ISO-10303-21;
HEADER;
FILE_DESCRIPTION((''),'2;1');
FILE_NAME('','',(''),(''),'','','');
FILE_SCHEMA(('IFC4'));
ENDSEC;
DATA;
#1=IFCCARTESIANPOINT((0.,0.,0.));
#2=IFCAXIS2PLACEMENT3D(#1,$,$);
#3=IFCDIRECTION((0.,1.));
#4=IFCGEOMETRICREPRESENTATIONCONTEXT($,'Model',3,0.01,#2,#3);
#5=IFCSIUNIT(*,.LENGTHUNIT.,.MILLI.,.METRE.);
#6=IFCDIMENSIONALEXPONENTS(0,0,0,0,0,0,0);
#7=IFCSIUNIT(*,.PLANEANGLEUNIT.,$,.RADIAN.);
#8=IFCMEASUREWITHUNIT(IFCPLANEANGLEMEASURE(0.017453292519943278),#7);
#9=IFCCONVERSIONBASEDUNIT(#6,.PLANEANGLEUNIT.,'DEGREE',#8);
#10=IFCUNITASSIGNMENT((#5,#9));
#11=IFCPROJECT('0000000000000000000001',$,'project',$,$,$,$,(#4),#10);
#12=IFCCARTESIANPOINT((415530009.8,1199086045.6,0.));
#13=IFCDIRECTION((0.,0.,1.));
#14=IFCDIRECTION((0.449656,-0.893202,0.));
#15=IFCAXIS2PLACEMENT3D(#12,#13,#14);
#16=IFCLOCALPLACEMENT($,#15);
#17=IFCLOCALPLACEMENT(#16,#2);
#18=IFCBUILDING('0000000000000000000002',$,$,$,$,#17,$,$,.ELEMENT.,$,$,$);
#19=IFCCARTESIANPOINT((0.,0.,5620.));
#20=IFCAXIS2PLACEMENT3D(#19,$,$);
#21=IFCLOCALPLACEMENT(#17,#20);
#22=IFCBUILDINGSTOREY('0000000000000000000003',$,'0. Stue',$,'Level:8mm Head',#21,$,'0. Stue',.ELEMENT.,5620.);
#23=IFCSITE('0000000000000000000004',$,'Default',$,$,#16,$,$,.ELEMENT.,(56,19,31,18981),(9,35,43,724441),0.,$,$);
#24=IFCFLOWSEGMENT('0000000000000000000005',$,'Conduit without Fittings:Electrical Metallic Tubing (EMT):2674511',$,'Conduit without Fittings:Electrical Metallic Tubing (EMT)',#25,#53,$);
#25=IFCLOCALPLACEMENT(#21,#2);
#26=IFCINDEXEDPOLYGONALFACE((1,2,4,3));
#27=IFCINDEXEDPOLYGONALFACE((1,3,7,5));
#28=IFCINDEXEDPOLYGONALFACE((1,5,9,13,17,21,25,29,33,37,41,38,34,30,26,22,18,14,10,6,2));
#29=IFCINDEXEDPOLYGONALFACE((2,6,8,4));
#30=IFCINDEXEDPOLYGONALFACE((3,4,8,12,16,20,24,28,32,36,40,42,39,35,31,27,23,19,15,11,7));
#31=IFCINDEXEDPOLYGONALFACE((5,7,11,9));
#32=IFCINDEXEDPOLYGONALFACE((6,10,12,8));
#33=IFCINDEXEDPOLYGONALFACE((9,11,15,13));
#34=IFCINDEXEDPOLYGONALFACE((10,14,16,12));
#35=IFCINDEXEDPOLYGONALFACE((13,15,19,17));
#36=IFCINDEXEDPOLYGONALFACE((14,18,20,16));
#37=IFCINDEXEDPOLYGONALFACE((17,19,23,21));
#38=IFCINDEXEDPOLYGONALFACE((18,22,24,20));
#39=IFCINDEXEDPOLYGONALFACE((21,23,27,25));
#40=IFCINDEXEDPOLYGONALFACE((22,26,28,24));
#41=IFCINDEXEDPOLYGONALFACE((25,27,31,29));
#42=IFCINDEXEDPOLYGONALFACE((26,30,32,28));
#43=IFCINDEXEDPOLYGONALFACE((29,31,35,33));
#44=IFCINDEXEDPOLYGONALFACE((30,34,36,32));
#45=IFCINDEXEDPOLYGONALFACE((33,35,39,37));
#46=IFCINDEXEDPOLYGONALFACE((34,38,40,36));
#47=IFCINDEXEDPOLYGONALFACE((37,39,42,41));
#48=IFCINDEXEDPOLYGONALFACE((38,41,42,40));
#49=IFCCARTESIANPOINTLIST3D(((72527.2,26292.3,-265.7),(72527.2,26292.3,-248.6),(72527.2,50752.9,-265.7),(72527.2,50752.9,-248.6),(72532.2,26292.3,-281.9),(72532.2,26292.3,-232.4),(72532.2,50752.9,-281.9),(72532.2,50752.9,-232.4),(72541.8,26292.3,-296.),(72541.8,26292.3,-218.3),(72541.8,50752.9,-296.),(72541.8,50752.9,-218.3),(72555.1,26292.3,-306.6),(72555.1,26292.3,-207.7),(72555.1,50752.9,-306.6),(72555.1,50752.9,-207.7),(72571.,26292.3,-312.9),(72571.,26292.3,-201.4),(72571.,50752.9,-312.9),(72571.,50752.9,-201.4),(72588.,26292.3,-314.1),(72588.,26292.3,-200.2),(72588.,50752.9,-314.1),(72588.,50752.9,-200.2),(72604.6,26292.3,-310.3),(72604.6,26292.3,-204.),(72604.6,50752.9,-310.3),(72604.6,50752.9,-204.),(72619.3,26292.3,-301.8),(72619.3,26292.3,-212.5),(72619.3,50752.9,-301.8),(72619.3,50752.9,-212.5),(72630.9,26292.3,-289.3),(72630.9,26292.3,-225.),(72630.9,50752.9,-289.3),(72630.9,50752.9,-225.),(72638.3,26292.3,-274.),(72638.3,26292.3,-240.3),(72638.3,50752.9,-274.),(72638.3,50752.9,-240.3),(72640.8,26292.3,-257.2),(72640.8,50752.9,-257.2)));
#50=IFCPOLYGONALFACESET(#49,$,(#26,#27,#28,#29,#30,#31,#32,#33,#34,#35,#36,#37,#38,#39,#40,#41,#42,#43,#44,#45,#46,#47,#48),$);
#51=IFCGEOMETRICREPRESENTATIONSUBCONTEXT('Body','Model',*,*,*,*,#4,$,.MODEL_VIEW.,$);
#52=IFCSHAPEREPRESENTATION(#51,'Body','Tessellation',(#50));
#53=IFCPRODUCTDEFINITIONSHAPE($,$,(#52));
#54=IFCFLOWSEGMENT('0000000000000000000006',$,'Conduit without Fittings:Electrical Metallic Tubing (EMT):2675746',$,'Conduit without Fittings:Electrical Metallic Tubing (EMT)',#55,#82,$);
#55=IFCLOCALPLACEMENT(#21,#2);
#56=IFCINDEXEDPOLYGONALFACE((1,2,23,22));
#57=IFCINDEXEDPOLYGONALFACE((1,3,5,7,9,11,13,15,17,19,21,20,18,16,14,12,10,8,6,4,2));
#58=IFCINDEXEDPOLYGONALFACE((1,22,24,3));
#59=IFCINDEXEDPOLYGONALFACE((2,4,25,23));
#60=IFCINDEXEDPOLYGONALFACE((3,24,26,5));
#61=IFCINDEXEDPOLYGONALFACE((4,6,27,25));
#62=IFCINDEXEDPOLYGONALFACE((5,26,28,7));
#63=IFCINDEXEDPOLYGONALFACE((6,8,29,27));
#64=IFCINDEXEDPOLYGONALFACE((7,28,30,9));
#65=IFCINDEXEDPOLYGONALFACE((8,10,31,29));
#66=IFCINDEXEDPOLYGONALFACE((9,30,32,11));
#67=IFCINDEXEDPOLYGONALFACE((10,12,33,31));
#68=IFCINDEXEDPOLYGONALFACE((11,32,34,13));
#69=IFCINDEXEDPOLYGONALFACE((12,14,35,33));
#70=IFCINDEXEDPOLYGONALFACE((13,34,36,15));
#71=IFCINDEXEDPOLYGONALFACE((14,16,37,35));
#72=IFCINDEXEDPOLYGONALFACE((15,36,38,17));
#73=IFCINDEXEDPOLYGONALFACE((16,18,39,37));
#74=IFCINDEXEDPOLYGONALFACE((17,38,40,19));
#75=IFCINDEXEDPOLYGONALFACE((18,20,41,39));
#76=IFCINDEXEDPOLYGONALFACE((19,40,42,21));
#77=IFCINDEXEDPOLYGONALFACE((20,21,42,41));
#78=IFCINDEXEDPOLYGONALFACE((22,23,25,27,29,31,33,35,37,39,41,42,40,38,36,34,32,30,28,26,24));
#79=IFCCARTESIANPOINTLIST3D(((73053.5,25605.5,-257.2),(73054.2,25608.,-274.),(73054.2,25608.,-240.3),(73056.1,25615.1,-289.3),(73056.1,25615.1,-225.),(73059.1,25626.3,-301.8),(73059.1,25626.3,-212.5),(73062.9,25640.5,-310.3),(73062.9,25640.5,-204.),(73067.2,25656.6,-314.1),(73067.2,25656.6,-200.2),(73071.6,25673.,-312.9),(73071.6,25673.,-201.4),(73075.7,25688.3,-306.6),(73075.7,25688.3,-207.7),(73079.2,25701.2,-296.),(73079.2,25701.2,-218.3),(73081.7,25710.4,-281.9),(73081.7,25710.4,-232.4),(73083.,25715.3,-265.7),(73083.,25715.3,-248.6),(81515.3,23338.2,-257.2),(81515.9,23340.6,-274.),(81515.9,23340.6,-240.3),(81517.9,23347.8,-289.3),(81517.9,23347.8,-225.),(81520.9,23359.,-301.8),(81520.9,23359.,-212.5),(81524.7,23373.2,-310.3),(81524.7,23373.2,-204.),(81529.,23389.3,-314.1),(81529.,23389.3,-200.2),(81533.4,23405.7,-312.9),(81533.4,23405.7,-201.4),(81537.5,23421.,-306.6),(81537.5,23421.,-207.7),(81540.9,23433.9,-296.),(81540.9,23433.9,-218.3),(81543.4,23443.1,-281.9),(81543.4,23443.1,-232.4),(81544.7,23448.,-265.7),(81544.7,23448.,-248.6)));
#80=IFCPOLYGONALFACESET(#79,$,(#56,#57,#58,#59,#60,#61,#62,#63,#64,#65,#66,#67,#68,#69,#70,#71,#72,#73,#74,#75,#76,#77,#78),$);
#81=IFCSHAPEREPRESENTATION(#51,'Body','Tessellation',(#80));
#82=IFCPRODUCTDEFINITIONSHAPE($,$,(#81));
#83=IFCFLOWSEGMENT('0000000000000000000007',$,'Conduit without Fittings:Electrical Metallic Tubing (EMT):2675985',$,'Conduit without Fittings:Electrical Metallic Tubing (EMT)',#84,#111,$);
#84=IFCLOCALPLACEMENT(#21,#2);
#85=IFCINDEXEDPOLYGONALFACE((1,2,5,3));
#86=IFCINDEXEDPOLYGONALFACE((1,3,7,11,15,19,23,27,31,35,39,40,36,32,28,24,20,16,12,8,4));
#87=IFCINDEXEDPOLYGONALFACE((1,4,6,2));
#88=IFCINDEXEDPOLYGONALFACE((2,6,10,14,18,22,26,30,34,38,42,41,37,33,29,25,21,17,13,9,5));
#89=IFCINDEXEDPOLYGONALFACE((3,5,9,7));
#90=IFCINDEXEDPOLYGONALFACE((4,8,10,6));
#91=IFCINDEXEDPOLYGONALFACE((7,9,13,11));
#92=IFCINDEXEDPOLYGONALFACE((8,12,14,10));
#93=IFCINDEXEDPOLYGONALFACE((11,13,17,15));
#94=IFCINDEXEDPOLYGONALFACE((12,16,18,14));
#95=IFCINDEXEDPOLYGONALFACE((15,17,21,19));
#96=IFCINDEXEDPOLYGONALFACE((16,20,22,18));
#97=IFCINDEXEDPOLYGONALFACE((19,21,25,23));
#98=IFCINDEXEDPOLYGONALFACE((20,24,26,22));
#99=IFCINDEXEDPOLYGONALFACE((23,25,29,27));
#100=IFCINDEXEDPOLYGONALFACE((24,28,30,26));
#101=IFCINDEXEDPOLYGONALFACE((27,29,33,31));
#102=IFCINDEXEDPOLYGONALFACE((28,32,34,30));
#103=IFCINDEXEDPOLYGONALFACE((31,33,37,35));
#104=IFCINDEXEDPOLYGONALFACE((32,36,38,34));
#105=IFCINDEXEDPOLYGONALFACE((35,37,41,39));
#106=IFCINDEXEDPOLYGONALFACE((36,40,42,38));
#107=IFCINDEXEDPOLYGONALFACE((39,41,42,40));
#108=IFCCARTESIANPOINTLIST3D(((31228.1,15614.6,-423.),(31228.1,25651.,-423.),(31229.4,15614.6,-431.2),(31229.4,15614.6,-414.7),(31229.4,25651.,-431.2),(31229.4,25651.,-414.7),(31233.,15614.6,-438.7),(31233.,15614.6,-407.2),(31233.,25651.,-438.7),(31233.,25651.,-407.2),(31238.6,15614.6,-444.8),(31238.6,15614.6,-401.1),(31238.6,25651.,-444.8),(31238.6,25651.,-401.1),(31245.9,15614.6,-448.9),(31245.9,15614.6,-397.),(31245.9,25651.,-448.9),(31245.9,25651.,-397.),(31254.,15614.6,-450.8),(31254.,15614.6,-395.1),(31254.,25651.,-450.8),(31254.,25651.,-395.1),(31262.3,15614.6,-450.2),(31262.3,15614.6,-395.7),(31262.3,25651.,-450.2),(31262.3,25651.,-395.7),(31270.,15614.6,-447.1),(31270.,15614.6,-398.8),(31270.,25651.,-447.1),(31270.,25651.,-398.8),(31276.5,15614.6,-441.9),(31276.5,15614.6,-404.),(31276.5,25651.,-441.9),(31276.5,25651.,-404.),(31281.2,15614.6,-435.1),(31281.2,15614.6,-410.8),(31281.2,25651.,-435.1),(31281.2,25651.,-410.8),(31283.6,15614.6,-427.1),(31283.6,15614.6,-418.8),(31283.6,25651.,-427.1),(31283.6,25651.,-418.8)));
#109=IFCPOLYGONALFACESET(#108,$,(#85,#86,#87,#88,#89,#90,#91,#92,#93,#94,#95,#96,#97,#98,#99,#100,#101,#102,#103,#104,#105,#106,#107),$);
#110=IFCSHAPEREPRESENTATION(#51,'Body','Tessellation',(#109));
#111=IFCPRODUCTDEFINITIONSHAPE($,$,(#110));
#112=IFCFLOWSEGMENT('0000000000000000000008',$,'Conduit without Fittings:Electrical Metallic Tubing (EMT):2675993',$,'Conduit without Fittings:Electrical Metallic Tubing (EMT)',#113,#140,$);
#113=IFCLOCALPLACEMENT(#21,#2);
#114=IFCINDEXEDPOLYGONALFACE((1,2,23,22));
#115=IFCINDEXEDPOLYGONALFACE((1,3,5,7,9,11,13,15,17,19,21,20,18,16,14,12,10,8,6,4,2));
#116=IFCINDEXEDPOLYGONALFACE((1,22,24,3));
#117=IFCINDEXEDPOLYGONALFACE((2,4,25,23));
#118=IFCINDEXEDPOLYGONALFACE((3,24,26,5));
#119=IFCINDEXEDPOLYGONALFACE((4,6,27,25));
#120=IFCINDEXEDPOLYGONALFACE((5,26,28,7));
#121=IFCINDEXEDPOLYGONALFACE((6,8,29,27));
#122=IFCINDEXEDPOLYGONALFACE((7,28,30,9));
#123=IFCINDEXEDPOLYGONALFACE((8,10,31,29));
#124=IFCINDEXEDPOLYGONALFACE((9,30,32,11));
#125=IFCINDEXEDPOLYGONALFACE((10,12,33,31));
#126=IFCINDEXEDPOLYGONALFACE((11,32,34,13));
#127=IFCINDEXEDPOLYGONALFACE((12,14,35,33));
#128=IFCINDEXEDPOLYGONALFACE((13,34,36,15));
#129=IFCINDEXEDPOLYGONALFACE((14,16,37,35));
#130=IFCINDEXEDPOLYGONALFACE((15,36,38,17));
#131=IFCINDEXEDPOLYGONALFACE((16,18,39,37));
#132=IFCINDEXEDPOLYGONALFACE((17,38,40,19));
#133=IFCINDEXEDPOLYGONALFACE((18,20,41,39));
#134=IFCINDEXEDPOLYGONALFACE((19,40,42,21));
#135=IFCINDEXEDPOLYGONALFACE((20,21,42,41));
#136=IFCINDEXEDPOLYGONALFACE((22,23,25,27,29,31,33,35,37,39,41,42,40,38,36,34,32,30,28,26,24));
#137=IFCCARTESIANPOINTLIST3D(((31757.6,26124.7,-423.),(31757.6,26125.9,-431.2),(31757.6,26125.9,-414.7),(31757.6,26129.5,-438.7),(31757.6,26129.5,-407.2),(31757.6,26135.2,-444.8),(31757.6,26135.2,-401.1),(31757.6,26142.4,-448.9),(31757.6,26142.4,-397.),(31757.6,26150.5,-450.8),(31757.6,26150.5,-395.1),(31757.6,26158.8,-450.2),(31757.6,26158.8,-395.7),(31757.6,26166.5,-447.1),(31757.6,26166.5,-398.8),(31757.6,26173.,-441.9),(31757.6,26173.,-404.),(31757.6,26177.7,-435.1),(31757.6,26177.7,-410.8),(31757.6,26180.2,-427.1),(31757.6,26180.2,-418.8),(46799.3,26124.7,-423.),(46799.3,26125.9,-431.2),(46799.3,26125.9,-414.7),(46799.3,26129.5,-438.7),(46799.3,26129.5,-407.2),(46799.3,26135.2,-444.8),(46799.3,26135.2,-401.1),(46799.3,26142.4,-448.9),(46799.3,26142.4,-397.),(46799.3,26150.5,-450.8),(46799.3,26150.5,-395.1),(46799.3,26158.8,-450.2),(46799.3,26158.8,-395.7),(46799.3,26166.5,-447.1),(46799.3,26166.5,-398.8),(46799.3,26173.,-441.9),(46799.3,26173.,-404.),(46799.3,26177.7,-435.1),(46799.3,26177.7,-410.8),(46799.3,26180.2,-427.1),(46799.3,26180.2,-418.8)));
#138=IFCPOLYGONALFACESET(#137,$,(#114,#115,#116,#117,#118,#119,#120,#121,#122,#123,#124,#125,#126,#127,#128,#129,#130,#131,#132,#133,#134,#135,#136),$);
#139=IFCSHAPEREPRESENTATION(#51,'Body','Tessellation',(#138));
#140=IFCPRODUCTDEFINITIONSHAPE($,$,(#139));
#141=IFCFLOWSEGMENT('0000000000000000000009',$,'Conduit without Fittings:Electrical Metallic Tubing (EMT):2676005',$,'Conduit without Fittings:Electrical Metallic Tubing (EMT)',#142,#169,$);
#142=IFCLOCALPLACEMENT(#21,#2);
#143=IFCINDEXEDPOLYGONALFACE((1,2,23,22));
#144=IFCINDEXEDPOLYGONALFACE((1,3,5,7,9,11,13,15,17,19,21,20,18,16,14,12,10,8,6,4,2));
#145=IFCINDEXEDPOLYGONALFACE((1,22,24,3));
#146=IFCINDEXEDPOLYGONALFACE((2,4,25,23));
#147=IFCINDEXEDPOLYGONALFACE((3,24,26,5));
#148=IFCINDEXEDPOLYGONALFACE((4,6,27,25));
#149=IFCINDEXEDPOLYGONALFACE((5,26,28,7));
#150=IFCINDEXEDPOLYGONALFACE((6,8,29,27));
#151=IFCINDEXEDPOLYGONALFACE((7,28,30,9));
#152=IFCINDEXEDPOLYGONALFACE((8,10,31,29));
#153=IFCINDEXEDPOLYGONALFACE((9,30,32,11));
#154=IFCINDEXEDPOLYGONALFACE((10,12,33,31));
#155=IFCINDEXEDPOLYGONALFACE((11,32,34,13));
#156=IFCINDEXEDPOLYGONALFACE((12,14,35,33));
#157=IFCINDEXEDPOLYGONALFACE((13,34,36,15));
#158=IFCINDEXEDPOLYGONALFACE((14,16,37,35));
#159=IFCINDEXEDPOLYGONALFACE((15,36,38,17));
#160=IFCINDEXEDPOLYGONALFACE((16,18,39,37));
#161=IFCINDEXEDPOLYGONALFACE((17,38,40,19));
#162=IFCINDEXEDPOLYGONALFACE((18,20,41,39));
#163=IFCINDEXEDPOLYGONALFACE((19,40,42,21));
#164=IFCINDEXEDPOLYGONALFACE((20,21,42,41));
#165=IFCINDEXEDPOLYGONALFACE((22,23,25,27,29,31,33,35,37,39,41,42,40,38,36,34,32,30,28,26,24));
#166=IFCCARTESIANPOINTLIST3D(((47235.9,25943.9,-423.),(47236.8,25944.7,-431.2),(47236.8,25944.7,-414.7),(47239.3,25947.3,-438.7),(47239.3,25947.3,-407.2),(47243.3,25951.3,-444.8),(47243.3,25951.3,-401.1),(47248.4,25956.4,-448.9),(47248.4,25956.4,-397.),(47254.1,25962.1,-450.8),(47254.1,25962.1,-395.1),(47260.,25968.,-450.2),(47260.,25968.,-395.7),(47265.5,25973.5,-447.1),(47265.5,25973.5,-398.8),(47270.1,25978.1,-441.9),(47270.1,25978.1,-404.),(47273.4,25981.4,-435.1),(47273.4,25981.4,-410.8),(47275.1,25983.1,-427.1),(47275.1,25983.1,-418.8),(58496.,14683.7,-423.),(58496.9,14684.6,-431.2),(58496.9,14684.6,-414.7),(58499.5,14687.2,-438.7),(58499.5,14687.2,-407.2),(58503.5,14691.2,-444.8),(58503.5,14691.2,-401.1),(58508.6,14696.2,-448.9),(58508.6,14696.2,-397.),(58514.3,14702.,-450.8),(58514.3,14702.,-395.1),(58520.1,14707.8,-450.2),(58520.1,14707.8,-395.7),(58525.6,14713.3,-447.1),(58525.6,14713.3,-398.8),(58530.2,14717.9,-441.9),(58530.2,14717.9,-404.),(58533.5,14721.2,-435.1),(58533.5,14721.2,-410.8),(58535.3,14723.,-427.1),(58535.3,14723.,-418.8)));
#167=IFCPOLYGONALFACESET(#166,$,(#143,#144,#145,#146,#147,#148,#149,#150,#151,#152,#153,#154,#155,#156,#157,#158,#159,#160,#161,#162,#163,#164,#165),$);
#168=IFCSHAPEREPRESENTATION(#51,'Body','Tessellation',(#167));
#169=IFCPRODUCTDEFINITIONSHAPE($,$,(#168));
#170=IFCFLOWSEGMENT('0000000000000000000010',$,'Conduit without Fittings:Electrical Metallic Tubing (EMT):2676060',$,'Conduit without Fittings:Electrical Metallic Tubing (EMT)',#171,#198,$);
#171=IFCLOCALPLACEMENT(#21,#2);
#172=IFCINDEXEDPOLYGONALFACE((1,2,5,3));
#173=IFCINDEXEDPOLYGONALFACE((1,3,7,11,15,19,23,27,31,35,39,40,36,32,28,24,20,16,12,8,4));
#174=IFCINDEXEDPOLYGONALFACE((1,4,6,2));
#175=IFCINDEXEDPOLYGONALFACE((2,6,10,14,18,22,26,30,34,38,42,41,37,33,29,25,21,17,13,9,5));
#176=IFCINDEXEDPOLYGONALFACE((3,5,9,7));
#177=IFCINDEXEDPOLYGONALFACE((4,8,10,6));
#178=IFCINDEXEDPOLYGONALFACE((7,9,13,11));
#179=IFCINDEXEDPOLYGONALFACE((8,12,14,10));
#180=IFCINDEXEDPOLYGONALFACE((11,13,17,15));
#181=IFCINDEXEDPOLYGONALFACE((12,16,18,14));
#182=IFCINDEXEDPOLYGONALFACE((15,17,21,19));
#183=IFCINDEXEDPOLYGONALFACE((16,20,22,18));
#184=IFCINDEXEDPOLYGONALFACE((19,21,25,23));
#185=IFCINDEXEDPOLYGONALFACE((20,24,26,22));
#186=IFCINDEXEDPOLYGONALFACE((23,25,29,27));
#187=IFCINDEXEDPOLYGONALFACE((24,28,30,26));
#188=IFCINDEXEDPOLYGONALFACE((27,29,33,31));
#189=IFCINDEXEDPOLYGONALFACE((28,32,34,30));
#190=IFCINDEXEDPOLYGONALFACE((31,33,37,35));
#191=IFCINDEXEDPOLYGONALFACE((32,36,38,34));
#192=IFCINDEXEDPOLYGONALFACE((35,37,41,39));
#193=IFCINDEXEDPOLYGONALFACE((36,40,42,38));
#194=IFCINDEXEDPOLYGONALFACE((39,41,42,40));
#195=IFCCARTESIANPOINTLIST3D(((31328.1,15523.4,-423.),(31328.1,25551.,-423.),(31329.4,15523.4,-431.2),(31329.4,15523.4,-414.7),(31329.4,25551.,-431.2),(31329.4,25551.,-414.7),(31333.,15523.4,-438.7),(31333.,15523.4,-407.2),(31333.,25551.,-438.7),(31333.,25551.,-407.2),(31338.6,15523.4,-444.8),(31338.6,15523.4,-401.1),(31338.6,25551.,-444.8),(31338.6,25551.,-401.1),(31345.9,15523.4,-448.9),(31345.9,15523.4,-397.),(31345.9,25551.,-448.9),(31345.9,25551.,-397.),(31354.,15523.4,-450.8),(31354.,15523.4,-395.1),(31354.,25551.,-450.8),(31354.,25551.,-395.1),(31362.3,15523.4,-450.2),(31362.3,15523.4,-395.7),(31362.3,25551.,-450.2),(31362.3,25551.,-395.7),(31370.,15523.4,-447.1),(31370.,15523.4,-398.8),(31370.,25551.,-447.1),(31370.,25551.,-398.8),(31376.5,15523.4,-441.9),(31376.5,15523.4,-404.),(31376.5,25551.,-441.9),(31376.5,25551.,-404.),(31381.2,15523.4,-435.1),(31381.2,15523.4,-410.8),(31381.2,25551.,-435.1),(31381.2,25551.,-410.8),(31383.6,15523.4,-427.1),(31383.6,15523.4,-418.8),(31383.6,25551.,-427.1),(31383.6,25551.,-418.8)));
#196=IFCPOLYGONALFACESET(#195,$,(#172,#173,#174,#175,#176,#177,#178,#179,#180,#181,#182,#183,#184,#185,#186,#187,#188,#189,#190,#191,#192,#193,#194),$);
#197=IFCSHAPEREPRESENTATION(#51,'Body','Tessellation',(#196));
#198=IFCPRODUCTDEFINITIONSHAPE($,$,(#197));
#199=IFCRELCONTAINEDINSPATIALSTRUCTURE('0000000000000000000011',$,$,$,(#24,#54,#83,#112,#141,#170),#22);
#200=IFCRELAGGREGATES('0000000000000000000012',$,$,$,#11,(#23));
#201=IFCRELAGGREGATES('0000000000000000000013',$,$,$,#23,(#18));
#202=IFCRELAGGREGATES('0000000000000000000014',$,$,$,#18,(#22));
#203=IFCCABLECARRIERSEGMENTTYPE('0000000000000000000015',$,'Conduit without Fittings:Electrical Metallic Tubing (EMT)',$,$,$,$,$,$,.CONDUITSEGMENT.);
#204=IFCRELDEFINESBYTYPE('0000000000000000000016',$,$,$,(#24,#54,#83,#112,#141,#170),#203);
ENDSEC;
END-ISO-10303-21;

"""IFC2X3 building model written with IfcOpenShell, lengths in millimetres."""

from ifc_helpers import new_model, entity, si_unit, converted_unit, direction, frame, frame_2d, origin, origin_2d_with_axis, place, context, subcontext, project, spatial, circle, extrude, type_object, element, save


model = new_model("IFC2X3")

# Units and contexts
model_context = context("Model", 3, precision=0.01, world=origin(), true_north=direction((0.0, 1.0)))
body_context = subcontext(model_context, "Body", "Model", "MODEL_VIEW")
ifc_project = project(units=[si_unit("LENGTHUNIT", "METRE", prefix="MILLI"), converted_unit("PLANEANGLEUNIT", "DEGREE", entity("IfcPlaneAngleMeasure", 0.017453292519943278), si_unit("PLANEANGLEUNIT", "RADIAN"), dimensions=[0, 0, 0, 0, 0, 0, 0])], contexts=[model_context])

# Site, building, storey
site_placement = place(None, frame((415530009.8, 1199086045.6, 0.0), z_axis=(0.0, 0.0, 1.0), x_axis=(0.449656, -0.893202, 0.0)))
site = spatial("IfcSite", under=ifc_project, at=site_placement, Name="Default", CompositionType="ELEMENT", RefLatitude=(56, 19, 31, 18981), RefLongitude=(9, 35, 43, 724441), RefElevation=0.0)
building_placement = place(site_placement, origin())
building = spatial("IfcBuilding", under=site, at=building_placement, CompositionType="ELEMENT")
storey_placement = place(building_placement, frame((0.0, 0.0, 5620.0)))
storey = spatial("IfcBuildingStorey", under=building, at=storey_placement, Name="0. Stue", ObjectType="Level:8mm Head", LongName="0. Stue", CompositionType="ELEMENT", Elevation=5620.0)

# Flow segments
cable_carrier_segment_type_1 = type_object("IfcCableCarrierSegmentType", Name="Conduit without Fittings:Electrical Metallic Tubing (EMT)", PredefinedType="CONDUITSEGMENT")
flow_segment_1_placement = place(storey_placement, origin())
element("IfcFlowSegment", 1, at=flow_segment_1_placement, inside=storey, type_object=cable_carrier_segment_type_1, Name="Conduit without Fittings:Electrical Metallic Tubing (EMT):2674511", ObjectType="Conduit without Fittings:Electrical Metallic Tubing (EMT)", context=body_context, shape_type="SweptSolid", body=[
    extrude(circle(Radius=57.2, at=origin_2d_with_axis()), frame((72583.7, 26292.3, -257.2), z_axis=(0.0, 1.0, 0.0), x_axis=(1.0, 0.0, 0.0)), (0.0, 0.0, 1.0), 24460.6),
])
flow_segment_2_placement = place(storey_placement, origin())
element("IfcFlowSegment", 2, at=flow_segment_2_placement, inside=storey, type_object=cable_carrier_segment_type_1, Name="Conduit without Fittings:Electrical Metallic Tubing (EMT):2675746", ObjectType="Conduit without Fittings:Electrical Metallic Tubing (EMT)", context=body_context, shape_type="SweptSolid", body=[
    extrude(circle(Radius=57.2, at=frame_2d((0.0, 0.0), x_axis=(1.0, 0.0))), frame((81530.1, 23393.4, -257.2), z_axis=(-0.965926, 0.258819, 0.0), x_axis=(-0.258819, -0.965926, 0.0)), (0.0, 0.0, 1.0), 8760.2),
])
flow_segment_3_placement = place(storey_placement, origin())
element("IfcFlowSegment", 3, at=flow_segment_3_placement, inside=storey, type_object=cable_carrier_segment_type_1, Name="Conduit without Fittings:Electrical Metallic Tubing (EMT):2675985", ObjectType="Conduit without Fittings:Electrical Metallic Tubing (EMT)", context=body_context, shape_type="SweptSolid", body=[
    extrude(circle(Radius=27.9, at=frame_2d((0.0, 0.0), x_axis=(1.0, 0.0))), frame((31256.0, 15614.6, -423.0), z_axis=(0.0, 1.0, 0.0), x_axis=(-1.0, 0.0, 0.0)), (0.0, 0.0, 1.0), 10036.4),
])
flow_segment_4_placement = place(storey_placement, origin())
element("IfcFlowSegment", 4, at=flow_segment_4_placement, inside=storey, type_object=cable_carrier_segment_type_1, Name="Conduit without Fittings:Electrical Metallic Tubing (EMT):2675993", ObjectType="Conduit without Fittings:Electrical Metallic Tubing (EMT)", context=body_context, shape_type="SweptSolid", body=[
    extrude(circle(Radius=27.9, at=origin_2d_with_axis()), frame((31757.6, 26152.6, -423.0), z_axis=(1.0, 0.0, 0.0), x_axis=(0.0, -1.0, 0.0)), (0.0, 0.0, 1.0), 15041.7),
])
flow_segment_5_placement = place(storey_placement, origin())
element("IfcFlowSegment", 5, at=flow_segment_5_placement, inside=storey, type_object=cable_carrier_segment_type_1, Name="Conduit without Fittings:Electrical Metallic Tubing (EMT):2676005", ObjectType="Conduit without Fittings:Electrical Metallic Tubing (EMT)", context=body_context, shape_type="SweptSolid", body=[
    extrude(circle(Radius=27.9, at=origin_2d_with_axis()), frame((47255.6, 25963.6, -423.0), z_axis=(0.707107, -0.707107, 0.0), x_axis=(-0.707107, -0.707107, 0.0)), (0.0, 0.0, 1.0), 15924.2),
])
flow_segment_6_placement = place(storey_placement, origin())
element("IfcFlowSegment", 6, at=flow_segment_6_placement, inside=storey, type_object=cable_carrier_segment_type_1, Name="Conduit without Fittings:Electrical Metallic Tubing (EMT):2676060", ObjectType="Conduit without Fittings:Electrical Metallic Tubing (EMT)", context=body_context, shape_type="SweptSolid", body=[
    extrude(circle(Radius=27.9, at=frame_2d((0.0, 0.0), x_axis=(1.0, 0.0))), frame((31356.0, 15523.4, -423.0), z_axis=(0.0, 1.0, 0.0), x_axis=(-1.0, 0.0, 0.0)), (0.0, 0.0, 1.0), 10027.6),
])

save(model, "model.ifc")
